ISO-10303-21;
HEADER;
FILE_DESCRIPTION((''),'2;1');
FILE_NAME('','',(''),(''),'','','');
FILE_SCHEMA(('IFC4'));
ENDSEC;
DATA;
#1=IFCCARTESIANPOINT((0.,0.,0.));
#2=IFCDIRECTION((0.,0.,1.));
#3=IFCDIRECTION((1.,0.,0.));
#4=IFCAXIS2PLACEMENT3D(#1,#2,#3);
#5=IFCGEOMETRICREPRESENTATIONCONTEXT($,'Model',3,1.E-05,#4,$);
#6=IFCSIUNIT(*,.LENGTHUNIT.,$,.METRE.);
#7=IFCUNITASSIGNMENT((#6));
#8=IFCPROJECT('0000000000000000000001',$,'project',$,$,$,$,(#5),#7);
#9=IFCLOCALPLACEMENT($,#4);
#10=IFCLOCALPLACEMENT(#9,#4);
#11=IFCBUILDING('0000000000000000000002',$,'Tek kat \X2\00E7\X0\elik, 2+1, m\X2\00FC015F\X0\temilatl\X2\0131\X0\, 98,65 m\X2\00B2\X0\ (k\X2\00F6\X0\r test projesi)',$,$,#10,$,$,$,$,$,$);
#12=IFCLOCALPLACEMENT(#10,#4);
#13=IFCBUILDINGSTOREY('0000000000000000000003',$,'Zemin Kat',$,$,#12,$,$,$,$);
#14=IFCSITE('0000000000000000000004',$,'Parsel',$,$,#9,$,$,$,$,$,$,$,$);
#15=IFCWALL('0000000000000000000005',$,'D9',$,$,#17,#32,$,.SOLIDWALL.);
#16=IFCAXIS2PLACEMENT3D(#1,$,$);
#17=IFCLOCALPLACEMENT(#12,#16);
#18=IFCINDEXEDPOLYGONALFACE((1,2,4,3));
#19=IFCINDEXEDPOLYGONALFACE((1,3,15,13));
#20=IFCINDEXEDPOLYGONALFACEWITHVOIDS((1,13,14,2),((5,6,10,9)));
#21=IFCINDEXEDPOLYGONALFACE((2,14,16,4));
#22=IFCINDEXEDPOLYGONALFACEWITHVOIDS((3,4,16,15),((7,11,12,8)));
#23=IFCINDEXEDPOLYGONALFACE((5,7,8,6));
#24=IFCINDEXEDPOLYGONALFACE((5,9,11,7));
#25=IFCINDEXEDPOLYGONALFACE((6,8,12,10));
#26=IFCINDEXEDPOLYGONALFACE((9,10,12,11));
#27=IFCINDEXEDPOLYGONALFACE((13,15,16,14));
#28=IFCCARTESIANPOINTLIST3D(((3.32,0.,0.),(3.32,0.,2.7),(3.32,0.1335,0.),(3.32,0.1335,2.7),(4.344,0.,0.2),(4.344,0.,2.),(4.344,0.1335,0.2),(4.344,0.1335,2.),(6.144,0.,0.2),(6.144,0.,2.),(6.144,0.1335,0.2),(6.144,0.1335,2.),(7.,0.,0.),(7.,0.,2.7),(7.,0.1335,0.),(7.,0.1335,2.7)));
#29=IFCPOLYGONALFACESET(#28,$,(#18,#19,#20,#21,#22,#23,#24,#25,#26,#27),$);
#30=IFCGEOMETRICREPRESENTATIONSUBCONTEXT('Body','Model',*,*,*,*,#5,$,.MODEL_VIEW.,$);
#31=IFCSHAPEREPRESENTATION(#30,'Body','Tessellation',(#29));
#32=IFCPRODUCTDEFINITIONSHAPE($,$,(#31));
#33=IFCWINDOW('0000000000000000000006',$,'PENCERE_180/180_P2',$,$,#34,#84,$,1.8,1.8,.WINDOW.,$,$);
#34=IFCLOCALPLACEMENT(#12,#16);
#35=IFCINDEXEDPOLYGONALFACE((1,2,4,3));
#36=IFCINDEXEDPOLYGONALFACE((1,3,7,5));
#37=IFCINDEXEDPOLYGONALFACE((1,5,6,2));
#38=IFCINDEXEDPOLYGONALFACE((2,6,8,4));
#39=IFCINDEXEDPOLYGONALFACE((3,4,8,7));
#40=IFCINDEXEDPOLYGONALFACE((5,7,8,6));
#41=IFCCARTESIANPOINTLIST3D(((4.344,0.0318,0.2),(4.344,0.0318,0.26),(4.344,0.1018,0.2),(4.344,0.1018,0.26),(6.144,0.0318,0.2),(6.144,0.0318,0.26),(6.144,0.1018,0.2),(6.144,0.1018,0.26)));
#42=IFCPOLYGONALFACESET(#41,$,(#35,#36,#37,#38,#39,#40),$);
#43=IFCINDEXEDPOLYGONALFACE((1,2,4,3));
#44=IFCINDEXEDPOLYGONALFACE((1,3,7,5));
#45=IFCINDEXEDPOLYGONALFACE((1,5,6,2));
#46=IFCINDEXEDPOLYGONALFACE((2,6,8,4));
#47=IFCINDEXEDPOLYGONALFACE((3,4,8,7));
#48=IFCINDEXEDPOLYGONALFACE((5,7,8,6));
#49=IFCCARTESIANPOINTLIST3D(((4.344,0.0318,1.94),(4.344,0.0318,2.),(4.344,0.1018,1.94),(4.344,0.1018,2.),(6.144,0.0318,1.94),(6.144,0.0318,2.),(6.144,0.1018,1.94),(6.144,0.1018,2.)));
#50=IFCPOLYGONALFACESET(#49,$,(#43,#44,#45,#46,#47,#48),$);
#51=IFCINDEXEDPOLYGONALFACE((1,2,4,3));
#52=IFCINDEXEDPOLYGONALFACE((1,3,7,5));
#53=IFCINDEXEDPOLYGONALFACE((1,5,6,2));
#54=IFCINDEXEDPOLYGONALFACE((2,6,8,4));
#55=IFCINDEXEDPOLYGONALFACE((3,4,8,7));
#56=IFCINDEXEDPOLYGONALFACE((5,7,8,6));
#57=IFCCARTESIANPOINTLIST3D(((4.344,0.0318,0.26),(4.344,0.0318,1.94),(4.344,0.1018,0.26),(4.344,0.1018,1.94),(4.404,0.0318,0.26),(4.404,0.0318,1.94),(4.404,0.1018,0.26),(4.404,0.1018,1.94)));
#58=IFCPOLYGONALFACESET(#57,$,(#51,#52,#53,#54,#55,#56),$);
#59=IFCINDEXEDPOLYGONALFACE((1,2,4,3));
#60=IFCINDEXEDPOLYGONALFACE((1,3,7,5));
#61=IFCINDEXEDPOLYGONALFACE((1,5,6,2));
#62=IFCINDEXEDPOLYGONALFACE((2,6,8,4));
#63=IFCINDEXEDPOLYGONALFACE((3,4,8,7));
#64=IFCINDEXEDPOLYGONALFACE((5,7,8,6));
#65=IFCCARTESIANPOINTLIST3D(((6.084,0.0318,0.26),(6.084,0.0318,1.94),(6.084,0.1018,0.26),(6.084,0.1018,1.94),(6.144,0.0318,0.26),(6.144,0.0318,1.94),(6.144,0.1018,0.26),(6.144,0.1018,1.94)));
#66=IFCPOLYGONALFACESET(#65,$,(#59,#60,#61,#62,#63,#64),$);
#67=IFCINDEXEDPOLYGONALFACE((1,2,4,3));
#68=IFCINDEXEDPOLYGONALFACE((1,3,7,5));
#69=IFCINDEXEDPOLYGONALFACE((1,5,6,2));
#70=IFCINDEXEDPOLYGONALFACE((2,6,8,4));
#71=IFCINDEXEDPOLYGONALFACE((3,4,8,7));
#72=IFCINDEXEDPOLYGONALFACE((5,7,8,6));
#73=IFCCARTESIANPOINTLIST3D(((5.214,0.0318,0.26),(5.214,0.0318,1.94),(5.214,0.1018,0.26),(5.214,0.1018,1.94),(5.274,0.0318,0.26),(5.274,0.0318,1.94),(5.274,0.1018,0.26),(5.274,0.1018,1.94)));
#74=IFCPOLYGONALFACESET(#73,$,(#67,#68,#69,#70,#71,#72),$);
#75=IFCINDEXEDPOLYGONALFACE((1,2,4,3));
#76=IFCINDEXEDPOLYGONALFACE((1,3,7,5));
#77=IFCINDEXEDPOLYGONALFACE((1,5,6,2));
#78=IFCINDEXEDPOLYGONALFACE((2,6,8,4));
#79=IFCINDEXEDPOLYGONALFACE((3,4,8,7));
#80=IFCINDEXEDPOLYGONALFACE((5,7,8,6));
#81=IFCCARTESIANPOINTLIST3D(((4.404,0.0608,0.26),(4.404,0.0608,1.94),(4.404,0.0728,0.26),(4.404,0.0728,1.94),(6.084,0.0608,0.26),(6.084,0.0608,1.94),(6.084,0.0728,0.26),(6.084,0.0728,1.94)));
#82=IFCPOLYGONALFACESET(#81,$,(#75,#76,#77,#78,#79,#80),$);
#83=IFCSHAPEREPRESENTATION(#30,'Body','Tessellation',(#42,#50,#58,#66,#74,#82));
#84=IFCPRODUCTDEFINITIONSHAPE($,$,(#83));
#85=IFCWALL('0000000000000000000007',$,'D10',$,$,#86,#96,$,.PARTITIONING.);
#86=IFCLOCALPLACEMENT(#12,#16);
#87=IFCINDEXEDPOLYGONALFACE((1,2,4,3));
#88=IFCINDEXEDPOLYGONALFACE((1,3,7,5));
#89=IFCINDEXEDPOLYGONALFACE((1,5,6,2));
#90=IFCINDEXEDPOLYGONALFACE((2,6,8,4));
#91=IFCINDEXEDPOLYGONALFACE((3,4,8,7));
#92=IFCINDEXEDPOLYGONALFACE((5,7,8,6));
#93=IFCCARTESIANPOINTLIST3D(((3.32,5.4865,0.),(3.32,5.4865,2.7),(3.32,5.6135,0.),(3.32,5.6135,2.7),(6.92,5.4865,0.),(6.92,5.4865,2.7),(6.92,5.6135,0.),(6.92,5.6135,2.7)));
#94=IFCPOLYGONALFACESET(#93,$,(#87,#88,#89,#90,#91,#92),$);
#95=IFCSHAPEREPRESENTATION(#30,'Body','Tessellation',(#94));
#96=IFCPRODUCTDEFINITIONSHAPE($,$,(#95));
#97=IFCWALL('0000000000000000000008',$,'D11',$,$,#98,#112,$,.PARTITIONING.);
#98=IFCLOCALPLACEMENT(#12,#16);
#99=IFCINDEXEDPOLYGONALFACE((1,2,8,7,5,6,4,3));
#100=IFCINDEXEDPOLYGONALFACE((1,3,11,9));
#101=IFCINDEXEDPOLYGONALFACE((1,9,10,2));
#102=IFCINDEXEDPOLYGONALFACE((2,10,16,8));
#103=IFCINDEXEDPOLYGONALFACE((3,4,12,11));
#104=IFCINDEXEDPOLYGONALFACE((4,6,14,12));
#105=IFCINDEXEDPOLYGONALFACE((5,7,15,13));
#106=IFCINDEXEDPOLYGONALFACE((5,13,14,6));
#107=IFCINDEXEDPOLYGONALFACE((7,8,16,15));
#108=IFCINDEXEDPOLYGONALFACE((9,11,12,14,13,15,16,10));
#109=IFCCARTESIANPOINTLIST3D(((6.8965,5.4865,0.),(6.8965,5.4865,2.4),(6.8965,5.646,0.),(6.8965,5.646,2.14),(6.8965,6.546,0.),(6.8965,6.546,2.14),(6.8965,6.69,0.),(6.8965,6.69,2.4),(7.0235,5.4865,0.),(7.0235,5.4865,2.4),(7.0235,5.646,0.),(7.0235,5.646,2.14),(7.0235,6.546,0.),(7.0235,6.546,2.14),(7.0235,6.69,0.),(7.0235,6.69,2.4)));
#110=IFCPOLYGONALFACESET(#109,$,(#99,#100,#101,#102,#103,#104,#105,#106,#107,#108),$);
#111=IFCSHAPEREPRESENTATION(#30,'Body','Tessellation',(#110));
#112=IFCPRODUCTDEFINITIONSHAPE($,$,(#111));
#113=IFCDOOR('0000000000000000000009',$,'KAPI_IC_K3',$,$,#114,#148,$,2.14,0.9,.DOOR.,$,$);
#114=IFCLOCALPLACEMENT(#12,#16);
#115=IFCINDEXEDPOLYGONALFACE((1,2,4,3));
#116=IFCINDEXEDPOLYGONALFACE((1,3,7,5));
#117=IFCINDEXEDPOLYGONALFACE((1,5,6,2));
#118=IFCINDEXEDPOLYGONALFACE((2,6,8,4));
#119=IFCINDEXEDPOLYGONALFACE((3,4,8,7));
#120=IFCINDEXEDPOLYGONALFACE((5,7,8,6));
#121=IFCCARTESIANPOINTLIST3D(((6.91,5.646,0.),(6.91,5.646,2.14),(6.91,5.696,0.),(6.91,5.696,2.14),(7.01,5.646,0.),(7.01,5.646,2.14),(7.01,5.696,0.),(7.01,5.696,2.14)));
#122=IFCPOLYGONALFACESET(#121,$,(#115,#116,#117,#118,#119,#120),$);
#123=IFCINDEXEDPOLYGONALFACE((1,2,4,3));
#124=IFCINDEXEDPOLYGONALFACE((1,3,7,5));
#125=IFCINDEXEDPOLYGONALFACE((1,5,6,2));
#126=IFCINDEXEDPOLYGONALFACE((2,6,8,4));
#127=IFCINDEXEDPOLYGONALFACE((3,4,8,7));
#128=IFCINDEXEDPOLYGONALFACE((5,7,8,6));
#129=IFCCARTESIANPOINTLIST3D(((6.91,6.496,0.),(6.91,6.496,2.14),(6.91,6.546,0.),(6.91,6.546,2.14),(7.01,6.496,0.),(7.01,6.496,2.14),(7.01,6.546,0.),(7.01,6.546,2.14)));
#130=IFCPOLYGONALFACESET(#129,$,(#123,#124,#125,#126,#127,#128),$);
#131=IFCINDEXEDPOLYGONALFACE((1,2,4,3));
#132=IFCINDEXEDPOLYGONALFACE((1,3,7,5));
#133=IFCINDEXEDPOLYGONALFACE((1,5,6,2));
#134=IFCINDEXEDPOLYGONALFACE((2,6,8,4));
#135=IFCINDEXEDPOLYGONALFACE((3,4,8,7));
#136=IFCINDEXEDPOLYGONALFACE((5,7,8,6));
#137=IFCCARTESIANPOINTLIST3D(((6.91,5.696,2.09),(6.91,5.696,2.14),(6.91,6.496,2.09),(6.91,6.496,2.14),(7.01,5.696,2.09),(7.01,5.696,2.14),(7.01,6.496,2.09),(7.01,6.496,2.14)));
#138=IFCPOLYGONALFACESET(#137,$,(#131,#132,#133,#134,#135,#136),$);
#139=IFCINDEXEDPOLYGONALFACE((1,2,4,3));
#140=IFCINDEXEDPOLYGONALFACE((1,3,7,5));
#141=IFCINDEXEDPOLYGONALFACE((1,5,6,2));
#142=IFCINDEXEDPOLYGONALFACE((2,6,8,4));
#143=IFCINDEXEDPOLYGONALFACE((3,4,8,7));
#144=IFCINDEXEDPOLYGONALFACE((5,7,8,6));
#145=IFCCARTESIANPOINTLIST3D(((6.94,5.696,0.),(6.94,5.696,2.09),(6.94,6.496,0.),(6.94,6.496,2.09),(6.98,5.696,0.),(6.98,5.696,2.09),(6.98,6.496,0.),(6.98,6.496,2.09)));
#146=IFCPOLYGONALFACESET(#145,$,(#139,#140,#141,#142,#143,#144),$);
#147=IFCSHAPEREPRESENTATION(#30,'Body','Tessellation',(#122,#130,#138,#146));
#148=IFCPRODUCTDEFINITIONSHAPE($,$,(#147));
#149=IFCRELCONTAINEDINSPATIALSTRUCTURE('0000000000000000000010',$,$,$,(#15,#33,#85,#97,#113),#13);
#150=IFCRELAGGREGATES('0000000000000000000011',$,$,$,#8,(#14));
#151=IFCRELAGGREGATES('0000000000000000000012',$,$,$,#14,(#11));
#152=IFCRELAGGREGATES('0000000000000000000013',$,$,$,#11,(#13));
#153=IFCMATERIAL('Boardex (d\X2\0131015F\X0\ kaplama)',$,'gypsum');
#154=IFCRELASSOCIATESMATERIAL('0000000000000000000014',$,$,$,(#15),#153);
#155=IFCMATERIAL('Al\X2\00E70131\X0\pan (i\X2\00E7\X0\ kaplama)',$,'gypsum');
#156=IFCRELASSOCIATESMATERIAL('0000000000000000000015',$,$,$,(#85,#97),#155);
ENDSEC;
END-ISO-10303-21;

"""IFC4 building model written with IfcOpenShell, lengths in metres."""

from ifc_helpers import new_model, si_unit, frame, origin_with_axes, place, context, subcontext, project, spatial, line, indexed_curve, outline, extrude, material, element, fill, save


model = new_model("IFC4")

# Units and contexts
model_context = context("Model", 3, precision=1e-05, world=origin_with_axes())
body_context = subcontext(model_context, "Body", "Model", "MODEL_VIEW")
ifc_project = project(units=[si_unit("LENGTHUNIT", "METRE")], contexts=[model_context])

# Site, building, storey
site_placement = place(None, origin_with_axes())
site = spatial("IfcSite", under=ifc_project, at=site_placement, Name="Parsel")
building_placement = place(site_placement, origin_with_axes())
building = spatial("IfcBuilding", under=site, at=building_placement, Name="Tek kat çelik, 2+1, müştemilatlı, 98,65 m² (kör test projesi)")
storey_placement = place(building_placement, origin_with_axes())
storey = spatial("IfcBuildingStorey", under=building, at=storey_placement, Name="Zemin Kat")

# Shared definitions
ifc_material_1 = material(Name="Boardex (dış kaplama)", Category="gypsum")

# Wall, opening, window
wall_1_placement = place(storey_placement, origin_with_axes())
wall_1 = element("IfcWall", 1, at=wall_1_placement, inside=storey, material=ifc_material_1, Name="D9", PredefinedType="SOLIDWALL", context=body_context, shape_type="SweptSolid", body=[
    extrude(outline(indexed_curve([(0.0, 0.0), (3.68, 0.0), (3.68, 0.1335), (0.0, 0.1335)], segments=[line(1, 2, 3, 4, 1)])), frame((3.32, 0.0, 0.0), z_axis=(0.0, 0.0, 1.0), x_axis=(1.0, 0.0, 0.0)), (0.0, 0.0, 1.0), 2.7),
])
opening_1_placement = place(wall_1_placement, origin_with_axes())
opening_1 = element("IfcOpeningElement", 2, at=opening_1_placement, cuts=wall_1, PredefinedType="OPENING", context=body_context, shape_type="SweptSolid", body=[
    extrude(outline(indexed_curve([(0.0, 0.0), (1.8, 0.0), (1.8, 0.1735), (0.0, 0.1735)], segments=[line(1, 2, 3, 4, 1)])), frame((4.344, -0.02, 0.2), z_axis=(0.0, 0.0, 1.0), x_axis=(1.0, 0.0, 0.0)), (0.0, 0.0, 1.0), 1.8),
])
window_1_placement = place(storey_placement, origin_with_axes())
window_1 = element("IfcWindow", 3, at=window_1_placement, inside=storey, Name="PENCERE_180/180_P2", OverallHeight=1.8, OverallWidth=1.8, PredefinedType="WINDOW", context=body_context, shape_type="SweptSolid", body=[
    extrude(outline(indexed_curve([(0.0, 0.0), (1.8, 0.0), (1.8, 0.07), (0.0, 0.07)], segments=[line(1, 2, 3, 4, 1)])), frame((4.344, 0.0318, 0.2), z_axis=(0.0, 0.0, 1.0), x_axis=(1.0, 0.0, 0.0)), (0.0, 0.0, 1.0), 0.06),
    extrude(outline(indexed_curve([(0.0, 0.0), (1.8, 0.0), (1.8, 0.07), (0.0, 0.07)], segments=[line(1, 2, 3, 4, 1)])), frame((4.344, 0.0318, 1.94), z_axis=(0.0, 0.0, 1.0), x_axis=(1.0, 0.0, 0.0)), (0.0, 0.0, 1.0), 0.06),
    extrude(outline(indexed_curve([(0.0, 0.0), (0.06, 0.0), (0.06, 0.07), (0.0, 0.07)], segments=[line(1, 2, 3, 4, 1)])), frame((4.344, 0.0318, 0.26), z_axis=(0.0, 0.0, 1.0), x_axis=(1.0, 0.0, 0.0)), (0.0, 0.0, 1.0), 1.68),
    extrude(outline(indexed_curve([(0.0, 0.0), (0.06, 0.0), (0.06, 0.07), (0.0, 0.07)], segments=[line(1, 2, 3, 4, 1)])), frame((6.084, 0.0318, 0.26), z_axis=(0.0, 0.0, 1.0), x_axis=(1.0, 0.0, 0.0)), (0.0, 0.0, 1.0), 1.68),
    extrude(outline(indexed_curve([(0.0, 0.0), (0.06, 0.0), (0.06, 0.07), (0.0, 0.07)], segments=[line(1, 2, 3, 4, 1)])), frame((5.214, 0.0318, 0.26), z_axis=(0.0, 0.0, 1.0), x_axis=(1.0, 0.0, 0.0)), (0.0, 0.0, 1.0), 1.68),
    extrude(outline(indexed_curve([(0.0, 0.0), (1.68, 0.0), (1.68, 0.012), (0.0, 0.012)], segments=[line(1, 2, 3, 4, 1)])), frame((4.404, 0.0608, 0.26), z_axis=(0.0, 0.0, 1.0), x_axis=(1.0, 0.0, 0.0)), (0.0, 0.0, 1.0), 1.68),
])
fill(opening_1, window_1)

# Wall
ifc_material_2 = material(Name="Alçıpan (iç kaplama)", Category="gypsum")
wall_2_placement = place(storey_placement, origin_with_axes())
element("IfcWall", 4, at=wall_2_placement, inside=storey, material=ifc_material_2, Name="D10", PredefinedType="PARTITIONING", context=body_context, shape_type="SweptSolid", body=[
    extrude(outline(indexed_curve([(0.0, 0.0), (3.6, 0.0), (3.6, 0.127), (0.0, 0.127)], segments=[line(1, 2, 3, 4, 1)])), frame((3.32, 5.4865, 0.0), z_axis=(0.0, 0.0, 1.0), x_axis=(1.0, 0.0, 0.0)), (0.0, 0.0, 1.0), 2.7),
])

# Wall, opening, door
wall_3_placement = place(storey_placement, origin_with_axes())
wall_3 = element("IfcWall", 5, at=wall_3_placement, inside=storey, material=ifc_material_2, Name="D11", PredefinedType="PARTITIONING", context=body_context, shape_type="SweptSolid", body=[
    extrude(outline(indexed_curve([(0.0, 0.0), (0.127, 0.0), (0.127, 1.2035), (0.0, 1.2035)], segments=[line(1, 2, 3, 4, 1)])), frame((6.8965, 5.4865, 0.0), z_axis=(0.0, 0.0, 1.0), x_axis=(1.0, 0.0, 0.0)), (0.0, 0.0, 1.0), 2.4),
])
opening_2_placement = place(wall_3_placement, origin_with_axes())
opening_2 = element("IfcOpeningElement", 6, at=opening_2_placement, cuts=wall_3, PredefinedType="OPENING", context=body_context, shape_type="SweptSolid", body=[
    extrude(outline(indexed_curve([(0.0, 0.0), (0.167, 0.0), (0.167, 0.9), (0.0, 0.9)], segments=[line(1, 2, 3, 4, 1)])), frame((6.8765, 5.646, 0.0), z_axis=(0.0, 0.0, 1.0), x_axis=(1.0, 0.0, 0.0)), (0.0, 0.0, 1.0), 2.14),
])
door_1_placement = place(storey_placement, origin_with_axes())
door_1 = element("IfcDoor", 7, at=door_1_placement, inside=storey, Name="KAPI_IC_K3", OverallHeight=2.14, OverallWidth=0.9, PredefinedType="DOOR", context=body_context, shape_type="SweptSolid", body=[
    extrude(outline(indexed_curve([(0.0, 0.0), (0.1, 0.0), (0.1, 0.05), (0.0, 0.05)], segments=[line(1, 2, 3, 4, 1)])), frame((6.91, 5.646, 0.0), z_axis=(0.0, 0.0, 1.0), x_axis=(1.0, 0.0, 0.0)), (0.0, 0.0, 1.0), 2.14),
    extrude(outline(indexed_curve([(0.0, 0.0), (0.1, 0.0), (0.1, 0.05), (0.0, 0.05)], segments=[line(1, 2, 3, 4, 1)])), frame((6.91, 6.496, 0.0), z_axis=(0.0, 0.0, 1.0), x_axis=(1.0, 0.0, 0.0)), (0.0, 0.0, 1.0), 2.14),
    extrude(outline(indexed_curve([(0.0, 0.0), (0.1, 0.0), (0.1, 0.8), (0.0, 0.8)], segments=[line(1, 2, 3, 4, 1)])), frame((6.91, 5.696, 2.09), z_axis=(0.0, 0.0, 1.0), x_axis=(1.0, 0.0, 0.0)), (0.0, 0.0, 1.0), 0.05),
    extrude(outline(indexed_curve([(0.0, 0.0), (0.04, 0.0), (0.04, 0.8), (0.0, 0.8)], segments=[line(1, 2, 3, 4, 1)])), frame((6.94, 5.696, 0.0), z_axis=(0.0, 0.0, 1.0), x_axis=(1.0, 0.0, 0.0)), (0.0, 0.0, 1.0), 2.09),
])
fill(opening_2, door_1)

save(model, "model.ifc")
